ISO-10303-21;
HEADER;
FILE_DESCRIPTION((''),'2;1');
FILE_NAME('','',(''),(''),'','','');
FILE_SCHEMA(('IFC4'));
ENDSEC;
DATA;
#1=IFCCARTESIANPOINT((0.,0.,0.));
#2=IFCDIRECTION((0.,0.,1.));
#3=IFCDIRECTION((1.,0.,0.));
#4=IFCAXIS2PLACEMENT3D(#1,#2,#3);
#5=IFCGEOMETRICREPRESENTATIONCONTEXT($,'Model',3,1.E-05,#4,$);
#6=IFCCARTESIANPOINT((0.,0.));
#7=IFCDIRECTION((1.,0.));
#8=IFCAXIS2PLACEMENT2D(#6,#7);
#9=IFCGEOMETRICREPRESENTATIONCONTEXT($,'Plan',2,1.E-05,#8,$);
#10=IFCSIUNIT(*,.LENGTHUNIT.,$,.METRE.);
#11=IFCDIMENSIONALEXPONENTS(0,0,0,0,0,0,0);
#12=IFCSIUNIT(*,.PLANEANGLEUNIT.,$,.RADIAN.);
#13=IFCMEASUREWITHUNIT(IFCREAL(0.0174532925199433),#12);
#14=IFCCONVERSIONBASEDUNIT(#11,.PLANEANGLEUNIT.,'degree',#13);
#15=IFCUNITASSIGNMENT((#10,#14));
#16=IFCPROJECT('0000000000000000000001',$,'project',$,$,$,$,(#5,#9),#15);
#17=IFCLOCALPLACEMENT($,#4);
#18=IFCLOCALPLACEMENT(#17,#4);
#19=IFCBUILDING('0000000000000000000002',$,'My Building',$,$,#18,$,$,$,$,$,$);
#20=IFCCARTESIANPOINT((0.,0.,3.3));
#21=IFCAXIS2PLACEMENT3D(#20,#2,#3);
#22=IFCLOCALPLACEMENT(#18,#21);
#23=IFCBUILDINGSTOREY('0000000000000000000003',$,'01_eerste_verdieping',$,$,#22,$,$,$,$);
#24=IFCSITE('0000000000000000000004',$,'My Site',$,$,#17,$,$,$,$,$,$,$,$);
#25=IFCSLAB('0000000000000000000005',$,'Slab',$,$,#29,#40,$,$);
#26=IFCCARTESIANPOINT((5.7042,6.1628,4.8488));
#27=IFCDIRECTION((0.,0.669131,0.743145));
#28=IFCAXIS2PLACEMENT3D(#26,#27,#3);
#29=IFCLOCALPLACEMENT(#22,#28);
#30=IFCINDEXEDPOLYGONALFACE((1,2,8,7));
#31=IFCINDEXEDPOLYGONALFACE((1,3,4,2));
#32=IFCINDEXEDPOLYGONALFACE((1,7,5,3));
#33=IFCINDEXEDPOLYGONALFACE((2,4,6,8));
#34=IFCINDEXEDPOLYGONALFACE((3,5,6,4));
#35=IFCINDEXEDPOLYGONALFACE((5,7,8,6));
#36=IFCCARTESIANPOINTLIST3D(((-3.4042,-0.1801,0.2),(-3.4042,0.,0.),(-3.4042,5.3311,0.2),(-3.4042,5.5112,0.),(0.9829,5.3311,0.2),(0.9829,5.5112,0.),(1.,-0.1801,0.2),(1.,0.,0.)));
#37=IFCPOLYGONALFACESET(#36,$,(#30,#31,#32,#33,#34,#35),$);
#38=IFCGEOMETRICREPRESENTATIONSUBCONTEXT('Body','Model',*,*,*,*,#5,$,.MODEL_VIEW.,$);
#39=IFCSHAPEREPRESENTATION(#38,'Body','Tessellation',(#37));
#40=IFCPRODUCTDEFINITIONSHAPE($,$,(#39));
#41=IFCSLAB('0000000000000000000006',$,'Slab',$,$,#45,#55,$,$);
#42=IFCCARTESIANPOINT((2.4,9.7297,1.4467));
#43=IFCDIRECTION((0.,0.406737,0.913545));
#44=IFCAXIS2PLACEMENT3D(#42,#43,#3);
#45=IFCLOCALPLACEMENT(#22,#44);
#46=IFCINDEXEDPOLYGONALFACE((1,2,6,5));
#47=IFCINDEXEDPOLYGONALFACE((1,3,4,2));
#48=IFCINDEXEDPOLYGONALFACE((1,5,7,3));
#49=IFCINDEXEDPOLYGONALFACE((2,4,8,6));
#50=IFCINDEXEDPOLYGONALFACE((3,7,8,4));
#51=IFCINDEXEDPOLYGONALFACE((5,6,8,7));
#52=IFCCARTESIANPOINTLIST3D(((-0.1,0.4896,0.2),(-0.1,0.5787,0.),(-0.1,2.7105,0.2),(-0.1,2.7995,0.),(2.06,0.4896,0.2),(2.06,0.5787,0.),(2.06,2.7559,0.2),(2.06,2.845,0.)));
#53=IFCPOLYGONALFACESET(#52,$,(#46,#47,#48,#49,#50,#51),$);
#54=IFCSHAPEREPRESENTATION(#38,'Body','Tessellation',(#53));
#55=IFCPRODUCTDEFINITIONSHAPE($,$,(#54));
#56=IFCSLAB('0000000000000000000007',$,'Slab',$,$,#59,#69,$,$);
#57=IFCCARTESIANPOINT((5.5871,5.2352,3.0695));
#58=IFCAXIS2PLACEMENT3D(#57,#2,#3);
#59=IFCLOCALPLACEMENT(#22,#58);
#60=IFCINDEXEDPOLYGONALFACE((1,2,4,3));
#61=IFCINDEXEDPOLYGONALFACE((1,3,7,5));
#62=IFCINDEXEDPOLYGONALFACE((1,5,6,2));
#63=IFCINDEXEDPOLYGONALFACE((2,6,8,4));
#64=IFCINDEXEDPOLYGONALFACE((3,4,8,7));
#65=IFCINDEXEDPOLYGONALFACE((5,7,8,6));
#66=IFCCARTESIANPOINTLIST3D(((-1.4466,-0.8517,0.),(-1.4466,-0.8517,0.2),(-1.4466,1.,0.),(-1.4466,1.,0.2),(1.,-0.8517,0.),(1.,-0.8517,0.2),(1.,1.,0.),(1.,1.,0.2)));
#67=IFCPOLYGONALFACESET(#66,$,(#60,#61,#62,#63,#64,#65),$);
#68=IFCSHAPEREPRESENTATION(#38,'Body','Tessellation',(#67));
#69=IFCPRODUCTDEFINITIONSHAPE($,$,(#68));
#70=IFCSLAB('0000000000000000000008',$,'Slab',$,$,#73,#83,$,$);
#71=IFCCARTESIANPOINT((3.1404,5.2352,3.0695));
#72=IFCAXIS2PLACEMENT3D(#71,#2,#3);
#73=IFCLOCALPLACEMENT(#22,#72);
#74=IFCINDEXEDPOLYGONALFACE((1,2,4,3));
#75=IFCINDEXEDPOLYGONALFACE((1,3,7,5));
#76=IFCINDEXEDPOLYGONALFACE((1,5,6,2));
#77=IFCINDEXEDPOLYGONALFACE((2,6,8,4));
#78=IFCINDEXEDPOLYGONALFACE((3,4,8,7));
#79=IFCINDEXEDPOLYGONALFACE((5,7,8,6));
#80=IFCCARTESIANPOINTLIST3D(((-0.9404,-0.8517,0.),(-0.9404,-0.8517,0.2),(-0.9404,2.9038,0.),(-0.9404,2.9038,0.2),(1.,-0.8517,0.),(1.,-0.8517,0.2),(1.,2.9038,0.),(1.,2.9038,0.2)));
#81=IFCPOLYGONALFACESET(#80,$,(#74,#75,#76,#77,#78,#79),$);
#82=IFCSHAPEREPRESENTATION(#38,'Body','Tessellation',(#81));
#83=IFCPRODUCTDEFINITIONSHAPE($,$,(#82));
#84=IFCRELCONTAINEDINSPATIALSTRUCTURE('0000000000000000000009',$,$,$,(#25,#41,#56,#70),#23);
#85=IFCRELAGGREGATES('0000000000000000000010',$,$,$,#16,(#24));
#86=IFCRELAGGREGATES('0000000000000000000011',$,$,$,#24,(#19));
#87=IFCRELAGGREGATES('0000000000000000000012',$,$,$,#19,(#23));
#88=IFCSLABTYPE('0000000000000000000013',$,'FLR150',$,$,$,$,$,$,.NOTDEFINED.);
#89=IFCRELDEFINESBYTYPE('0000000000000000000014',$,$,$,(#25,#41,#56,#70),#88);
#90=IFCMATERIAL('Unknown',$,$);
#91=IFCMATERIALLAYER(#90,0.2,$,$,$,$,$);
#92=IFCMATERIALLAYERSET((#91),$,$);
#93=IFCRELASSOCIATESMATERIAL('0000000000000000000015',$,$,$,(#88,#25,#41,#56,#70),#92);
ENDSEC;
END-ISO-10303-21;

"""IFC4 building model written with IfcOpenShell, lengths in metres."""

from ifc_helpers import new_model, entity, si_unit, converted_unit, frame, origin_with_axes, origin_2d_with_axis, place, context, subcontext, project, spatial, line, indexed_curve, outline, extrude, material, layer, layer_set, layer_usage, type_object, element, save


model = new_model("IFC4")

# Units and contexts
model_context = context("Model", 3, precision=1e-05, world=origin_with_axes())
plan_context = context("Plan", 2, precision=1e-05, world=origin_2d_with_axis())
body_context = subcontext(model_context, "Body", "Model", "MODEL_VIEW")
ifc_project = project(units=[si_unit("LENGTHUNIT", "METRE"), converted_unit("PLANEANGLEUNIT", "degree", entity("IfcReal", 0.0174532925199433), si_unit("PLANEANGLEUNIT", "RADIAN"), dimensions=[0, 0, 0, 0, 0, 0, 0])], contexts=[model_context, plan_context])

# Site, building, storey
site_placement = place(None, origin_with_axes())
site = spatial("IfcSite", under=ifc_project, at=site_placement, Name="My Site")
building_placement = place(site_placement, origin_with_axes())
building = spatial("IfcBuilding", under=site, at=building_placement, Name="My Building")
storey_placement = place(building_placement, frame((0.0, 0.0, 3.3), z_axis=(0.0, 0.0, 1.0), x_axis=(1.0, 0.0, 0.0)))
storey = spatial("IfcBuildingStorey", under=building, at=storey_placement, Name="01_eerste_verdieping")

# Slabs
ifc_material = material(Name="Unknown")
ifc_layer_1 = layer(ifc_material, 0.2)
ifc_layer_set_1 = layer_set([ifc_layer_1])
slab_type = type_object("IfcSlabType", Name="FLR150", PredefinedType="NOTDEFINED", material=ifc_layer_set_1)
ifc_layer_usage_1 = layer_usage(ifc_layer_set_1, "AXIS3", "POSITIVE", 0.0)
slab_1_placement = place(storey_placement, frame((5.7042, 6.1628, 4.8488), z_axis=(0.0, 0.669131, 0.743145), x_axis=(1.0, 0.0, 0.0)))
element("IfcSlab", 1, at=slab_1_placement, inside=storey, type_object=slab_type, material=ifc_layer_usage_1, Name="Slab", context=body_context, shape_type="SweptSolid", body=[
    extrude(outline(indexed_curve([(1.0, 0.0), (-3.4042, 0.0), (-3.4042, 5.5112), (0.9829, 5.5112)], segments=[line(4, 1), line(1, 2), line(2, 3), line(3, 4)], self_intersect=False)), None, (0.0, -0.669131, 0.743145), 0.2691),
])
ifc_layer_usage_2 = layer_usage(ifc_layer_set_1, "AXIS3", "POSITIVE", 0.0)
slab_2_placement = place(storey_placement, frame((2.4, 9.7297, 1.4467), z_axis=(0.0, 0.406737, 0.913545), x_axis=(1.0, 0.0, 0.0)))
element("IfcSlab", 2, at=slab_2_placement, inside=storey, type_object=slab_type, material=ifc_layer_usage_2, Name="Slab", context=body_context, shape_type="SweptSolid", body=[
    extrude(outline(indexed_curve([(2.06, 0.5787), (2.06, 2.845), (-0.1, 2.7995), (-0.1, 0.5787)], segments=[line(3, 2), line(2, 1), line(1, 4), line(4, 3)], self_intersect=False)), None, (0.0, -0.406737, 0.913545), 0.2189),
])
ifc_layer_usage_3 = layer_usage(ifc_layer_set_1, "AXIS3", "POSITIVE", 0.0)
slab_3_placement = place(storey_placement, frame((5.5871, 5.2352, 3.0695), z_axis=(0.0, 0.0, 1.0), x_axis=(1.0, 0.0, 0.0)))
element("IfcSlab", 3, at=slab_3_placement, inside=storey, type_object=slab_type, material=ifc_layer_usage_3, Name="Slab", context=body_context, shape_type="SweptSolid", body=[
    extrude(outline(indexed_curve([(1.0, -0.8517), (1.0, 1.0), (-1.4466, 1.0), (-1.4466, -0.8517)], segments=[line(4, 1), line(1, 2), line(2, 3), line(3, 4)], self_intersect=False)), None, (0.0, 0.0, 1.0), 0.2),
])
ifc_layer_usage_4 = layer_usage(ifc_layer_set_1, "AXIS3", "POSITIVE", 0.0)
slab_4_placement = place(storey_placement, frame((3.1404, 5.2352, 3.0695), z_axis=(0.0, 0.0, 1.0), x_axis=(1.0, 0.0, 0.0)))
element("IfcSlab", 4, at=slab_4_placement, inside=storey, type_object=slab_type, material=ifc_layer_usage_4, Name="Slab", context=body_context, shape_type="SweptSolid", body=[
    extrude(outline(indexed_curve([(-0.9404, -0.8517), (1.0, -0.8517), (1.0, 2.9038), (-0.9404, 2.9038)], segments=[line(3, 2), line(2, 1), line(1, 4), line(4, 3)], self_intersect=False)), None, (0.0, 0.0, 1.0), 0.2),
])

save(model, "model.ifc")
